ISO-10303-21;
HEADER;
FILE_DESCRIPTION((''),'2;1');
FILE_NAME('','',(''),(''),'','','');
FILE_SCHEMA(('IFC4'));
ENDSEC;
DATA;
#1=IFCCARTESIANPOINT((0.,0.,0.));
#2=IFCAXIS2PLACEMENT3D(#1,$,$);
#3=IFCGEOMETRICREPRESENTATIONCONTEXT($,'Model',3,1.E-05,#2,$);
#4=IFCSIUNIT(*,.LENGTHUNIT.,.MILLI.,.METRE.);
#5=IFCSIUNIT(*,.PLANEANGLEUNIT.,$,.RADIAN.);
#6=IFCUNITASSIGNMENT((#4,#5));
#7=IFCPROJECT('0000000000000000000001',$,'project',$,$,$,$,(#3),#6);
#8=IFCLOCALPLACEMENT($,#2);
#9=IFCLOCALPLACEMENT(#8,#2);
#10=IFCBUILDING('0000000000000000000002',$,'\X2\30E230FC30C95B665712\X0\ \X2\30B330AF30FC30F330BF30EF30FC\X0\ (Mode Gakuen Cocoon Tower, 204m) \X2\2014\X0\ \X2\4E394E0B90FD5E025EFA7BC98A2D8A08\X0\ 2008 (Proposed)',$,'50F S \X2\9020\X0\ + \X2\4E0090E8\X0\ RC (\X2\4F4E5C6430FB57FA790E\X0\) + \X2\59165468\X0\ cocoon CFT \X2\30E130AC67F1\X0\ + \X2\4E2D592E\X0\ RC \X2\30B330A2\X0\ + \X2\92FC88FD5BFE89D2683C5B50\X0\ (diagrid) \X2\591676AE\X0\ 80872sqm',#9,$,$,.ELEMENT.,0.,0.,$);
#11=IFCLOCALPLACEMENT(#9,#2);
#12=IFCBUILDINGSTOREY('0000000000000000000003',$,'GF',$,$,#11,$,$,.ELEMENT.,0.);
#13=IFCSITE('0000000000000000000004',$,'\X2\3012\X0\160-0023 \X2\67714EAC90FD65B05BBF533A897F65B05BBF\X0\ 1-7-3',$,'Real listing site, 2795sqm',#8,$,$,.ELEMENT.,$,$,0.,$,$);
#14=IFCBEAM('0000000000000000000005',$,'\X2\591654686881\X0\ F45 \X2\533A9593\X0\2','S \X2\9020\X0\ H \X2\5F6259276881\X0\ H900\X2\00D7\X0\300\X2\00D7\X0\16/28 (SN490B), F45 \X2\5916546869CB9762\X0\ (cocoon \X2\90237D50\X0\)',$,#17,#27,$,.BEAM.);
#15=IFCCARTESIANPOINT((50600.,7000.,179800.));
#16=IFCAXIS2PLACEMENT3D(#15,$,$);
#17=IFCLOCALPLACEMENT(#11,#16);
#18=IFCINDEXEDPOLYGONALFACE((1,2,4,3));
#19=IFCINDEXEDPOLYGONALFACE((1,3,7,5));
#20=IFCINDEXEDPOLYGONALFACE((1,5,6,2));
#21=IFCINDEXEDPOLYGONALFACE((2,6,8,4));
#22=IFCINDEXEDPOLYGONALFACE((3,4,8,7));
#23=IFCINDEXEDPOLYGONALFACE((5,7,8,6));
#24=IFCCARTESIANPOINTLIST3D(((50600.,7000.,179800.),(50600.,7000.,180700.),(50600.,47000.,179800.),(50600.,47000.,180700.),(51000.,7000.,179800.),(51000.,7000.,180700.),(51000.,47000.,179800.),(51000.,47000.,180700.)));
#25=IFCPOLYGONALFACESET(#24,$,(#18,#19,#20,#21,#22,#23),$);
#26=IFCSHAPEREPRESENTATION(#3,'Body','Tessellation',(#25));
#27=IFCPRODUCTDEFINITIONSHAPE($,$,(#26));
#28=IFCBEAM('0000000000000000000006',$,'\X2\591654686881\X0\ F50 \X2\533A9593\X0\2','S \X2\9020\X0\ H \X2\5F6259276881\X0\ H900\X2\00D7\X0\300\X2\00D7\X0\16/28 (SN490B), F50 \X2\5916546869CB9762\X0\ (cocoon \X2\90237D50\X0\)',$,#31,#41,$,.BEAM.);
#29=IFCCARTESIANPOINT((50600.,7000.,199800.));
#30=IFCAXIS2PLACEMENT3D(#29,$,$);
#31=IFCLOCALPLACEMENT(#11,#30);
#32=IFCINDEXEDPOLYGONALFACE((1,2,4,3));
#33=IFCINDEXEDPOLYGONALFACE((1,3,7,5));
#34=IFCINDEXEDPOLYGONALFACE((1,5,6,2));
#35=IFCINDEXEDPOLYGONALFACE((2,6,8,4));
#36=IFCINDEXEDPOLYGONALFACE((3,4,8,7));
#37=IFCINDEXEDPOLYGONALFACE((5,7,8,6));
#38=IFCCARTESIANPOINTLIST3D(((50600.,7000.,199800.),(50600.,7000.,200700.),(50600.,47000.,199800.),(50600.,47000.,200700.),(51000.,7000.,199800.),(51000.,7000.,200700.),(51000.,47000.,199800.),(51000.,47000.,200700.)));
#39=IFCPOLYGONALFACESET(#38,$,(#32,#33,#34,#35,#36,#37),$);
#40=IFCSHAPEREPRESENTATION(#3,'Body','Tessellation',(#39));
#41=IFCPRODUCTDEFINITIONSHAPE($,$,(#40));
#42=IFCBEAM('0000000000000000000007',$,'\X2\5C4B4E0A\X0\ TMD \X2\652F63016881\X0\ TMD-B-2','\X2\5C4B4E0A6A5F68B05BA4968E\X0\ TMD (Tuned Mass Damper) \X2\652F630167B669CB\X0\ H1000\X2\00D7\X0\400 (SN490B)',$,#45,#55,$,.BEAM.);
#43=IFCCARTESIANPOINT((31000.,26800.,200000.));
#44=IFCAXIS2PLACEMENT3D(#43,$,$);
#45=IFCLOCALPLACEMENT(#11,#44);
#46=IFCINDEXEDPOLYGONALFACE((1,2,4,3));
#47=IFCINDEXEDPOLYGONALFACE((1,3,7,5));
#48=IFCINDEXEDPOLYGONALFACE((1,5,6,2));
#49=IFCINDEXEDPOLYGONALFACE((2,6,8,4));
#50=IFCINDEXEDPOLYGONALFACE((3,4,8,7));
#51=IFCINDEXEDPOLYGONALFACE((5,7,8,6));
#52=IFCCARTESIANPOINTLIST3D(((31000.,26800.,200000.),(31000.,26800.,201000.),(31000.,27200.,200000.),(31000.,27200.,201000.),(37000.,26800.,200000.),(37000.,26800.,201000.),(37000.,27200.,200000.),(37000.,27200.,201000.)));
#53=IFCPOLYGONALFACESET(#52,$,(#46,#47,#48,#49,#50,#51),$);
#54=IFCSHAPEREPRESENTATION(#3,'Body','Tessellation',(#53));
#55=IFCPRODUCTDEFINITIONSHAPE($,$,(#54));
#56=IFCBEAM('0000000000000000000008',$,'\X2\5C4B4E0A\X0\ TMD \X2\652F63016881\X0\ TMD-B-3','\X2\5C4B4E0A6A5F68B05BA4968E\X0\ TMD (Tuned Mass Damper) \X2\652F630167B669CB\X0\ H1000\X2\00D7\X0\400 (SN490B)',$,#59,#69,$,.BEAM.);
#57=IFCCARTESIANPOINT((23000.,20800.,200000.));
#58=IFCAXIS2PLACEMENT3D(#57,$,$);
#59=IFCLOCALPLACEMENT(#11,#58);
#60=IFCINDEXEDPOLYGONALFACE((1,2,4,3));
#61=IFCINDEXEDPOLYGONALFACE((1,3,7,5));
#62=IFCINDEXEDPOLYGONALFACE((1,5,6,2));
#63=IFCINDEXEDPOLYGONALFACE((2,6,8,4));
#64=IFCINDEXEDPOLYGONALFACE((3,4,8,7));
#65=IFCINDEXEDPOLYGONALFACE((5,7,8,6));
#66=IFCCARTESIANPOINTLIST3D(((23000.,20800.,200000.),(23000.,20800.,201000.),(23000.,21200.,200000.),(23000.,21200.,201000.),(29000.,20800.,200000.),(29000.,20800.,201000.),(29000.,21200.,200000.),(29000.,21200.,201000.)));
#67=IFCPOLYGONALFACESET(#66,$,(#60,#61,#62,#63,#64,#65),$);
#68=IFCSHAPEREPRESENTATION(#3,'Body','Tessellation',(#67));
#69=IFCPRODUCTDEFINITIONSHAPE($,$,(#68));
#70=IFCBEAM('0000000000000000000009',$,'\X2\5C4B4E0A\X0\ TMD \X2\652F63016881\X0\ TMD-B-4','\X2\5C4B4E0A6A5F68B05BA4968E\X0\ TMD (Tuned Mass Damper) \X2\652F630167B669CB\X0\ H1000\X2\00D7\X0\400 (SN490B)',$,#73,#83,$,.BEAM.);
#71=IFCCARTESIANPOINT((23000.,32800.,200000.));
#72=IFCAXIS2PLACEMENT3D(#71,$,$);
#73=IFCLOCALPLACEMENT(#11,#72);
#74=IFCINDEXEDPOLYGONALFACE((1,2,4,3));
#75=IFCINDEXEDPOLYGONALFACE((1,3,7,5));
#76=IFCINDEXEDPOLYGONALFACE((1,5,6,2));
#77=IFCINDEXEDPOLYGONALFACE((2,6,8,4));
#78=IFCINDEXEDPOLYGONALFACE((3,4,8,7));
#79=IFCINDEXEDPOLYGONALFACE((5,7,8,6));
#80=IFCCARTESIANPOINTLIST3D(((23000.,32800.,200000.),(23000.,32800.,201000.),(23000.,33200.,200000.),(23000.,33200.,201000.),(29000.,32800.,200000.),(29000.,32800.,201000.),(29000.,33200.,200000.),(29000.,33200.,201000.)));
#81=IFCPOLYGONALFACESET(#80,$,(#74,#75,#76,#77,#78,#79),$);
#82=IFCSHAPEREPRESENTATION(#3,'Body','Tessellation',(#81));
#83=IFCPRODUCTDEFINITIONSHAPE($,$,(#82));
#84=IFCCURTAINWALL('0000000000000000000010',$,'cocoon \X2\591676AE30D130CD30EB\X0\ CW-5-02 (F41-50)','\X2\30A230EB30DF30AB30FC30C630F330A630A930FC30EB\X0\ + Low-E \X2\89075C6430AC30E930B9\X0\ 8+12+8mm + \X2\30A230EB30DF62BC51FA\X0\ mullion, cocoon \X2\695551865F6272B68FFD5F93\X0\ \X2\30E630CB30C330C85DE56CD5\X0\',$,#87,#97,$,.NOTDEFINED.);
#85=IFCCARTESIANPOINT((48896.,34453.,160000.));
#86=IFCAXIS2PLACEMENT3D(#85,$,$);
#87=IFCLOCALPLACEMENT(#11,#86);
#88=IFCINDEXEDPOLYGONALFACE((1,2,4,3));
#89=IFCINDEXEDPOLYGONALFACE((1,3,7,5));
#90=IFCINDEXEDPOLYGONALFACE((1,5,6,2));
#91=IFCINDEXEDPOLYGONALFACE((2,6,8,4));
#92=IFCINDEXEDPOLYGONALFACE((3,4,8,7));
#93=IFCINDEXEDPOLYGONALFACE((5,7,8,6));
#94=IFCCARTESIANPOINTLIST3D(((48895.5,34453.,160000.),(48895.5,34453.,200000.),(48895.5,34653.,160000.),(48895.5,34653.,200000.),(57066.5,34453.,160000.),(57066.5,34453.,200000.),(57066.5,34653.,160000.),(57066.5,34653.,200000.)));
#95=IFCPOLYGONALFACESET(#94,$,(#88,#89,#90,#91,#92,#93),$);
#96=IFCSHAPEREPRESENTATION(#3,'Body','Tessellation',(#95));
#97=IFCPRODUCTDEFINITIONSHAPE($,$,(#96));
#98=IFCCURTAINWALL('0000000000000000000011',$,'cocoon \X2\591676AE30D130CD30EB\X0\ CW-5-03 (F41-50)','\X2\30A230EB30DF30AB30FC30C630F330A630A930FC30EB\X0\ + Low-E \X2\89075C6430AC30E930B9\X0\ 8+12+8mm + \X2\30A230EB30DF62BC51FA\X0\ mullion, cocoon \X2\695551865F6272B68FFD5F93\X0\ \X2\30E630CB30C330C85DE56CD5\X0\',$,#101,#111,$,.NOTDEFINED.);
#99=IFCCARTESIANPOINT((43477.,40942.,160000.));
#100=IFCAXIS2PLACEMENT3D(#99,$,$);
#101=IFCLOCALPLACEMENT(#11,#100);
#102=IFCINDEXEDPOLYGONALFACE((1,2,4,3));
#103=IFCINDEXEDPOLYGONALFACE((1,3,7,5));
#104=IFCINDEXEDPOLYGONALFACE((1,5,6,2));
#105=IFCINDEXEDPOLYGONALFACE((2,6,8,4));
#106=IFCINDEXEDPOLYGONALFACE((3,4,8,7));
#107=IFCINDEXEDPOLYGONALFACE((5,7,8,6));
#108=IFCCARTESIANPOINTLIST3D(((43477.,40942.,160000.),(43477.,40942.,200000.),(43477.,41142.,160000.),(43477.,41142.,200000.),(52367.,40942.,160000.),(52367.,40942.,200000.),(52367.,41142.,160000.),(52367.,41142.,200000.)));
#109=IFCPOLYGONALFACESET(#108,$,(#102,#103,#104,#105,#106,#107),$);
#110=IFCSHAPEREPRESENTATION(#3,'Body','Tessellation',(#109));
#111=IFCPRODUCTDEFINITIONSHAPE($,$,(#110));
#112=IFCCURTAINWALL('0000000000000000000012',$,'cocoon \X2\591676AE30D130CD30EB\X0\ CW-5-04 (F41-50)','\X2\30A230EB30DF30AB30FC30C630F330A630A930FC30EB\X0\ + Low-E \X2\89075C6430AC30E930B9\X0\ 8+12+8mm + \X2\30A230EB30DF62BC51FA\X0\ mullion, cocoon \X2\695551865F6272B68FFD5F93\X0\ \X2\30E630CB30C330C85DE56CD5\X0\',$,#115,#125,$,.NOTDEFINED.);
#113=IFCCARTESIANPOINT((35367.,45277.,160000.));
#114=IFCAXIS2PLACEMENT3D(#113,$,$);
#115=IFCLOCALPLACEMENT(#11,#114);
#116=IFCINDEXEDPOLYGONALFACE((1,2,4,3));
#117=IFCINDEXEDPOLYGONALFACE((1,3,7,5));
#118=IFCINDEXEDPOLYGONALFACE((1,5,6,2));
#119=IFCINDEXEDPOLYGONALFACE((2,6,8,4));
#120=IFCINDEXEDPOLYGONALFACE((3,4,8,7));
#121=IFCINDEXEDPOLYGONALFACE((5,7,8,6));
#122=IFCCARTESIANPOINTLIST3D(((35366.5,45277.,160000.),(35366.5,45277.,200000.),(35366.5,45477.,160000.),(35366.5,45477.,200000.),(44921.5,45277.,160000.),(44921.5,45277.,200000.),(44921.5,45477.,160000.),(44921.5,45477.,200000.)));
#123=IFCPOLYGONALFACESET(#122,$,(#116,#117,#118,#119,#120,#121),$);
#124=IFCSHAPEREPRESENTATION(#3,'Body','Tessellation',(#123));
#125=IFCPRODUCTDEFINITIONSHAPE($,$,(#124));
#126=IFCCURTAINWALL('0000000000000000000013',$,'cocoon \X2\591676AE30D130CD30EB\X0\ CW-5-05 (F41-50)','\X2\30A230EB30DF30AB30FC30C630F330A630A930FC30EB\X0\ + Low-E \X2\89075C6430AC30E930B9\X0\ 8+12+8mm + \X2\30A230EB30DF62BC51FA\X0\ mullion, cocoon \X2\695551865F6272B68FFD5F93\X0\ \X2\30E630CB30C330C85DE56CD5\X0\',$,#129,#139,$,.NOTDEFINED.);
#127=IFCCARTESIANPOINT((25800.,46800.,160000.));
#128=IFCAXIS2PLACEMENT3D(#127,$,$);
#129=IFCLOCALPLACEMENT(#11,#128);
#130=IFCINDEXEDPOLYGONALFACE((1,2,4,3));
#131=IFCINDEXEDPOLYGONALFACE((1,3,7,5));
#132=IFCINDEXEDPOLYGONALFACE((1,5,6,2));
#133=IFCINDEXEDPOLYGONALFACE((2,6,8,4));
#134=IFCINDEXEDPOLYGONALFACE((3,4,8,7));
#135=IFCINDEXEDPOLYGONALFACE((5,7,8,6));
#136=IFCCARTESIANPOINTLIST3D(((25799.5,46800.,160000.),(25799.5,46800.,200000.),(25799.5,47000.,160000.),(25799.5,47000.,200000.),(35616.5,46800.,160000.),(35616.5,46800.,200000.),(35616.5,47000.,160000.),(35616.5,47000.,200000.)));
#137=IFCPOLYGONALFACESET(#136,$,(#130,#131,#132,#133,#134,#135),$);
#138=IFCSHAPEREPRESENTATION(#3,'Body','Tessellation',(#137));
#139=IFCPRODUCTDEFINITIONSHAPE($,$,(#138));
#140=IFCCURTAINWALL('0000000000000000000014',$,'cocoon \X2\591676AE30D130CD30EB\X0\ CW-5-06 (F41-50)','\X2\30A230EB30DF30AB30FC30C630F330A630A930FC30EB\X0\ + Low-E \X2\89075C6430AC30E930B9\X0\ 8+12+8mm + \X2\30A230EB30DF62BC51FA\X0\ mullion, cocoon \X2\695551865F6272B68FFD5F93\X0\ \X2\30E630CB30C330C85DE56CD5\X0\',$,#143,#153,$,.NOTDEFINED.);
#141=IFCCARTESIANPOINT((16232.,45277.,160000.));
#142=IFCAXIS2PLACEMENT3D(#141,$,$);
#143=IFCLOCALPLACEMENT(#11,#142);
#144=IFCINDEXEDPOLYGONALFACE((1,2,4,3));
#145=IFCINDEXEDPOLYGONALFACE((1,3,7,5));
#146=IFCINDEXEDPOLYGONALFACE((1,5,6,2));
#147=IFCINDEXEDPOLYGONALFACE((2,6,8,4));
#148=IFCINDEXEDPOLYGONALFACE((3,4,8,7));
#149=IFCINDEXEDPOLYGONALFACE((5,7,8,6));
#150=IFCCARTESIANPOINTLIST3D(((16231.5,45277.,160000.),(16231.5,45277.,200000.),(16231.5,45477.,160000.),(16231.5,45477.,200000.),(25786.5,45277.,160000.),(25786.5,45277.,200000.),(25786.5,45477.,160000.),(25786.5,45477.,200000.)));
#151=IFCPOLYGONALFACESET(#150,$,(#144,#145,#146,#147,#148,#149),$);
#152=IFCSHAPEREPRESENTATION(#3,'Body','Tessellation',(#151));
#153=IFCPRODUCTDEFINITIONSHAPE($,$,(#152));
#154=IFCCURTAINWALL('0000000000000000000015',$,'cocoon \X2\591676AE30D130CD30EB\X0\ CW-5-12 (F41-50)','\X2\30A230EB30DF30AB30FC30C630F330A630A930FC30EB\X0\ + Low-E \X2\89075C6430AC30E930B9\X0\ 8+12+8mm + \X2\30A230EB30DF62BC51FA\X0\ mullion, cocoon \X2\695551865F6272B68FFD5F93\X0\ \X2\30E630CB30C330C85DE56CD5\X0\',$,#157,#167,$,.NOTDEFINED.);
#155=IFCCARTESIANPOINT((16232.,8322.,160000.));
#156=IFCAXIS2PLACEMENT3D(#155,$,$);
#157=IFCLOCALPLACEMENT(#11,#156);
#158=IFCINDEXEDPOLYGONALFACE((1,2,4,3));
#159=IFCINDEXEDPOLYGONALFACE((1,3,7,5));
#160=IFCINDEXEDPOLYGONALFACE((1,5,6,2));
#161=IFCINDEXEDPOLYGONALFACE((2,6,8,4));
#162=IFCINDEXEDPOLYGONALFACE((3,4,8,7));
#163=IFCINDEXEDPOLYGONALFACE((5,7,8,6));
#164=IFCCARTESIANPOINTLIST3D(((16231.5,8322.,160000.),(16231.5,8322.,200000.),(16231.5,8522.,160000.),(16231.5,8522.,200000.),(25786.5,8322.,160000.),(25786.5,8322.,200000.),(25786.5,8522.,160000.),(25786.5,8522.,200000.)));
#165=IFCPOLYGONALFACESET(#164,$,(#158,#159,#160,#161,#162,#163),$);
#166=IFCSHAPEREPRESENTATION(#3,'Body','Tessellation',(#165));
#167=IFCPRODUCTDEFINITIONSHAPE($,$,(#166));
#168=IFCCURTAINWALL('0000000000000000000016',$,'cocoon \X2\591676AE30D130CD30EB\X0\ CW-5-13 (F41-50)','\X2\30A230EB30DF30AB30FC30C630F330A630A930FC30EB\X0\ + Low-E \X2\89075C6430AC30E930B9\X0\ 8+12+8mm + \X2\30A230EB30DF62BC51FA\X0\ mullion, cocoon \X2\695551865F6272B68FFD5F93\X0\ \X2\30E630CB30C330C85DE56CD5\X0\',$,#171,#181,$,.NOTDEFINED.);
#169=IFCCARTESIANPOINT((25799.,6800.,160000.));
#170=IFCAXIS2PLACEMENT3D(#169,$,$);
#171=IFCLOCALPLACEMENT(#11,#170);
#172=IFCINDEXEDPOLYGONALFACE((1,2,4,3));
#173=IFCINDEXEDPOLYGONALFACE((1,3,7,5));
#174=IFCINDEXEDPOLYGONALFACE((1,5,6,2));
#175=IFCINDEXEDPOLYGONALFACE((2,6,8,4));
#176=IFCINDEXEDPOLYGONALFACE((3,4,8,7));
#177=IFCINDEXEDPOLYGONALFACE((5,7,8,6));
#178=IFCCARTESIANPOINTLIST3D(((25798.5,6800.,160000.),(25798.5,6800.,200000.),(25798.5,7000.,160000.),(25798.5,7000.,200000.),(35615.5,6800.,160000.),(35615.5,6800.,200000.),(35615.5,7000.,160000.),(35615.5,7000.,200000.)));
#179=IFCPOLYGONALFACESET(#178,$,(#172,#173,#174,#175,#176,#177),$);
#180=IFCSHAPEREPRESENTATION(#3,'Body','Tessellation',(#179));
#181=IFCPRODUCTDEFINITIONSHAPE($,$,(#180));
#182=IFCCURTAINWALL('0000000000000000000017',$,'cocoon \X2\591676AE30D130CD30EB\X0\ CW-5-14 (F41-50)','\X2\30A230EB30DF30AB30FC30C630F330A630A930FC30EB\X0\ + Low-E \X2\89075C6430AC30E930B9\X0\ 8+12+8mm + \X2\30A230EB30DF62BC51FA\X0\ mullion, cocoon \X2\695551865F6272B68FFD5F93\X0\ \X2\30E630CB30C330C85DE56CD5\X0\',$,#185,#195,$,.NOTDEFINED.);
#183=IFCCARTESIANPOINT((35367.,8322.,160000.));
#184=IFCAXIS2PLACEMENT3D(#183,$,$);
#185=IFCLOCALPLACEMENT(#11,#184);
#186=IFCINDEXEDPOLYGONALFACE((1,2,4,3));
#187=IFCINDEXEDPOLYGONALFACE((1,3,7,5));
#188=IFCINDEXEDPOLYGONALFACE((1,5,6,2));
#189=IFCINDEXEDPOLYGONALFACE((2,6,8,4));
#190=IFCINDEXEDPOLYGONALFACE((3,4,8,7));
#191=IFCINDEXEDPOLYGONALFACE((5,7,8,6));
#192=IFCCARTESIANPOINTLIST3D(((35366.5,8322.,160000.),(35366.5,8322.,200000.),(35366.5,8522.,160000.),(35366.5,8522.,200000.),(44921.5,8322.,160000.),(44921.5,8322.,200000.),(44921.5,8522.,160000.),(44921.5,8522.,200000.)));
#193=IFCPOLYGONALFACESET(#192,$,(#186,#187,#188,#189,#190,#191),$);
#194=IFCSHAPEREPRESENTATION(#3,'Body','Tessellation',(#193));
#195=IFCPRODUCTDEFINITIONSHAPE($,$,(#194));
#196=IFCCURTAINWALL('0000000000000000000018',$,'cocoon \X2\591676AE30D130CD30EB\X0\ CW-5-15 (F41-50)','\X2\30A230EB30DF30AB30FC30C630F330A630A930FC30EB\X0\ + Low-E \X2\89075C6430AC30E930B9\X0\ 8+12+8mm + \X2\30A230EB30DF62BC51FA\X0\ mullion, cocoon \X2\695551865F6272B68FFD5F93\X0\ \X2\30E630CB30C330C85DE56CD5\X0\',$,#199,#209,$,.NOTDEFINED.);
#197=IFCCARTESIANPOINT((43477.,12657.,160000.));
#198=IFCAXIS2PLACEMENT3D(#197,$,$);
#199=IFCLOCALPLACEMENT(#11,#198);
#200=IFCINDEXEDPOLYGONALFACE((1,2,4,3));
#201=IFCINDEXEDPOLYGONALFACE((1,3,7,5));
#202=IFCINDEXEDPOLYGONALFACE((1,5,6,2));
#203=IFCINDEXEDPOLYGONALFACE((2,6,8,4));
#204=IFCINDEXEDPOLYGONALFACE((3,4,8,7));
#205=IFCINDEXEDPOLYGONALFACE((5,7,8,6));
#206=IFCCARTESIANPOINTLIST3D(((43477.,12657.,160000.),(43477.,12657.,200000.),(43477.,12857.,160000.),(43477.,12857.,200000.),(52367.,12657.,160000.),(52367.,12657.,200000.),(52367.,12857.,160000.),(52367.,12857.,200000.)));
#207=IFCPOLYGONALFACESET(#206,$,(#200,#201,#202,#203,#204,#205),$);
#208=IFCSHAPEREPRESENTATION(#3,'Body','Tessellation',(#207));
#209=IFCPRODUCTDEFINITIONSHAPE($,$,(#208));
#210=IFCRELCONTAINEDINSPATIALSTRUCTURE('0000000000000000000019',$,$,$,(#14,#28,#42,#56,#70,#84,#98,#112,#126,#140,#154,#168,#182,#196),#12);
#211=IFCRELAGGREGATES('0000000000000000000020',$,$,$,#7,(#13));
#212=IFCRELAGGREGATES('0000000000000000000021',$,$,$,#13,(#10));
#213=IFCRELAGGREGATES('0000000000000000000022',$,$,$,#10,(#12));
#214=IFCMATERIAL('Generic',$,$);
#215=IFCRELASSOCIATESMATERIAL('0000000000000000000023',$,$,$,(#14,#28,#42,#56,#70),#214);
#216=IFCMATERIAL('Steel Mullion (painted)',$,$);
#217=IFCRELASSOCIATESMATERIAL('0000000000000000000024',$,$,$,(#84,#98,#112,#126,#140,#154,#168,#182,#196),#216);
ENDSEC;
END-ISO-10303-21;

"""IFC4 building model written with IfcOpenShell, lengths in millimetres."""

from ifc_helpers import new_model, si_unit, frame, frame_2d, origin, place, context, project, spatial, rectangle, extrude, material, element, save


model = new_model("IFC4")

# Units and contexts
model_context = context("Model", 3, precision=1e-05, world=origin())
ifc_project = project(units=[si_unit("LENGTHUNIT", "METRE", prefix="MILLI"), si_unit("PLANEANGLEUNIT", "RADIAN")], contexts=[model_context])

# Site, building, storey
site_placement = place(None, origin())
site = spatial("IfcSite", under=ifc_project, at=site_placement, Name="〒160-0023 東京都新宿区西新宿 1-7-3", ObjectType="Real listing site, 2795sqm", CompositionType="ELEMENT", RefElevation=0.0)
building_placement = place(site_placement, origin())
building = spatial("IfcBuilding", under=site, at=building_placement, Name="モード学園 コクーンタワー (Mode Gakuen Cocoon Tower, 204m) — 丹下都市建築設計 2008 (Proposed)", ObjectType="50F S 造 + 一部 RC (低層・基礎) + 外周 cocoon CFT メガ柱 + 中央 RC コア + 鋼製対角格子 (diagrid) 外皮 80872sqm", CompositionType="ELEMENT", ElevationOfRefHeight=0.0, ElevationOfTerrain=0.0)
storey_placement = place(building_placement, origin())
storey = spatial("IfcBuildingStorey", under=building, at=storey_placement, Name="GF", CompositionType="ELEMENT", Elevation=0.0)

# Beams
ifc_material_1 = material(Name="Generic")
beam_1_placement = place(storey_placement, frame((50600.0, 7000.0, 179800.0)))
element("IfcBeam", 1, at=beam_1_placement, inside=storey, material=ifc_material_1, Name="外周梁 F45 区間2", Description="S 造 H 形大梁 H900×300×16/28 (SN490B), F45 外周構面 (cocoon 連結)", PredefinedType="BEAM", context=model_context, shape_type="SweptSolid", body=[
    extrude(rectangle(XDim=400.0, YDim=40000.0, at=frame_2d((200.0, 20000.0))), frame((50600.0, 7000.0, 179800.0)), (0.0, 0.0, 1.0), 900.0),
])
beam_2_placement = place(storey_placement, frame((50600.0, 7000.0, 199800.0)))
element("IfcBeam", 2, at=beam_2_placement, inside=storey, material=ifc_material_1, Name="外周梁 F50 区間2", Description="S 造 H 形大梁 H900×300×16/28 (SN490B), F50 外周構面 (cocoon 連結)", PredefinedType="BEAM", context=model_context, shape_type="SweptSolid", body=[
    extrude(rectangle(XDim=400.0, YDim=40000.0, at=frame_2d((200.0, 20000.0))), frame((50600.0, 7000.0, 199800.0)), (0.0, 0.0, 1.0), 900.0),
])
beam_3_placement = place(storey_placement, frame((31000.0, 26800.0, 200000.0)))
element("IfcBeam", 3, at=beam_3_placement, inside=storey, material=ifc_material_1, Name="屋上 TMD 支持梁 TMD-B-2", Description="屋上機械室階 TMD (Tuned Mass Damper) 支持架構 H1000×400 (SN490B)", PredefinedType="BEAM", context=model_context, shape_type="SweptSolid", body=[
    extrude(rectangle(XDim=6000.0, YDim=400.0, at=frame_2d((3000.0, 200.0))), frame((31000.0, 26800.0, 200000.0)), (0.0, 0.0, 1.0), 1000.0),
])
beam_4_placement = place(storey_placement, frame((23000.0, 20800.0, 200000.0)))
element("IfcBeam", 4, at=beam_4_placement, inside=storey, material=ifc_material_1, Name="屋上 TMD 支持梁 TMD-B-3", Description="屋上機械室階 TMD (Tuned Mass Damper) 支持架構 H1000×400 (SN490B)", PredefinedType="BEAM", context=model_context, shape_type="SweptSolid", body=[
    extrude(rectangle(XDim=6000.0, YDim=400.0, at=frame_2d((3000.0, 200.0))), frame((23000.0, 20800.0, 200000.0)), (0.0, 0.0, 1.0), 1000.0),
])
beam_5_placement = place(storey_placement, frame((23000.0, 32800.0, 200000.0)))
element("IfcBeam", 5, at=beam_5_placement, inside=storey, material=ifc_material_1, Name="屋上 TMD 支持梁 TMD-B-4", Description="屋上機械室階 TMD (Tuned Mass Damper) 支持架構 H1000×400 (SN490B)", PredefinedType="BEAM", context=model_context, shape_type="SweptSolid", body=[
    extrude(rectangle(XDim=6000.0, YDim=400.0, at=frame_2d((3000.0, 200.0))), frame((23000.0, 32800.0, 200000.0)), (0.0, 0.0, 1.0), 1000.0),
])

# Curtain walls
ifc_material_2 = material(Name="Steel Mullion (painted)")
curtain_wall_1_placement = place(storey_placement, frame((48896.0, 34453.0, 160000.0)))
element("IfcCurtainWall", 6, at=curtain_wall_1_placement, inside=storey, material=ifc_material_2, Name="cocoon 外皮パネル CW-5-02 (F41-50)", Description="アルミカーテンウォール + Low-E 複層ガラス 8+12+8mm + アルミ押出 mullion, cocoon 楕円形状追従 ユニット工法", PredefinedType="NOTDEFINED", context=model_context, shape_type="SweptSolid", body=[
    extrude(rectangle(XDim=8171.0, YDim=200.0, at=frame_2d((4085.0, 100.0))), frame((48896.0, 34453.0, 160000.0)), (0.0, 0.0, 1.0), 40000.0),
])
curtain_wall_2_placement = place(storey_placement, frame((43477.0, 40942.0, 160000.0)))
element("IfcCurtainWall", 7, at=curtain_wall_2_placement, inside=storey, material=ifc_material_2, Name="cocoon 外皮パネル CW-5-03 (F41-50)", Description="アルミカーテンウォール + Low-E 複層ガラス 8+12+8mm + アルミ押出 mullion, cocoon 楕円形状追従 ユニット工法", PredefinedType="NOTDEFINED", context=model_context, shape_type="SweptSolid", body=[
    extrude(rectangle(XDim=8890.0, YDim=200.0, at=frame_2d((4445.0, 100.0))), frame((43477.0, 40942.0, 160000.0)), (0.0, 0.0, 1.0), 40000.0),
])
curtain_wall_3_placement = place(storey_placement, frame((35367.0, 45277.0, 160000.0)))
element("IfcCurtainWall", 8, at=curtain_wall_3_placement, inside=storey, material=ifc_material_2, Name="cocoon 外皮パネル CW-5-04 (F41-50)", Description="アルミカーテンウォール + Low-E 複層ガラス 8+12+8mm + アルミ押出 mullion, cocoon 楕円形状追従 ユニット工法", PredefinedType="NOTDEFINED", context=model_context, shape_type="SweptSolid", body=[
    extrude(rectangle(XDim=9555.0, YDim=200.0, at=frame_2d((4777.0, 100.0))), frame((35367.0, 45277.0, 160000.0)), (0.0, 0.0, 1.0), 40000.0),
])
curtain_wall_4_placement = place(storey_placement, frame((25800.0, 46800.0, 160000.0)))
element("IfcCurtainWall", 9, at=curtain_wall_4_placement, inside=storey, material=ifc_material_2, Name="cocoon 外皮パネル CW-5-05 (F41-50)", Description="アルミカーテンウォール + Low-E 複層ガラス 8+12+8mm + アルミ押出 mullion, cocoon 楕円形状追従 ユニット工法", PredefinedType="NOTDEFINED", context=model_context, shape_type="SweptSolid", body=[
    extrude(rectangle(XDim=9817.0, YDim=200.0, at=frame_2d((4908.0, 100.0))), frame((25800.0, 46800.0, 160000.0)), (0.0, 0.0, 1.0), 40000.0),
])
curtain_wall_5_placement = place(storey_placement, frame((16232.0, 45277.0, 160000.0)))
element("IfcCurtainWall", 10, at=curtain_wall_5_placement, inside=storey, material=ifc_material_2, Name="cocoon 外皮パネル CW-5-06 (F41-50)", Description="アルミカーテンウォール + Low-E 複層ガラス 8+12+8mm + アルミ押出 mullion, cocoon 楕円形状追従 ユニット工法", PredefinedType="NOTDEFINED", context=model_context, shape_type="SweptSolid", body=[
    extrude(rectangle(XDim=9555.0, YDim=200.0, at=frame_2d((4777.0, 100.0))), frame((16232.0, 45277.0, 160000.0)), (0.0, 0.0, 1.0), 40000.0),
])
curtain_wall_6_placement = place(storey_placement, frame((16232.0, 8322.0, 160000.0)))
element("IfcCurtainWall", 11, at=curtain_wall_6_placement, inside=storey, material=ifc_material_2, Name="cocoon 外皮パネル CW-5-12 (F41-50)", Description="アルミカーテンウォール + Low-E 複層ガラス 8+12+8mm + アルミ押出 mullion, cocoon 楕円形状追従 ユニット工法", PredefinedType="NOTDEFINED", context=model_context, shape_type="SweptSolid", body=[
    extrude(rectangle(XDim=9555.0, YDim=200.0, at=frame_2d((4777.0, 100.0))), frame((16232.0, 8322.0, 160000.0)), (0.0, 0.0, 1.0), 40000.0),
])
curtain_wall_7_placement = place(storey_placement, frame((25799.0, 6800.0, 160000.0)))
element("IfcCurtainWall", 12, at=curtain_wall_7_placement, inside=storey, material=ifc_material_2, Name="cocoon 外皮パネル CW-5-13 (F41-50)", Description="アルミカーテンウォール + Low-E 複層ガラス 8+12+8mm + アルミ押出 mullion, cocoon 楕円形状追従 ユニット工法", PredefinedType="NOTDEFINED", context=model_context, shape_type="SweptSolid", body=[
    extrude(rectangle(XDim=9817.0, YDim=200.0, at=frame_2d((4908.0, 100.0))), frame((25799.0, 6800.0, 160000.0)), (0.0, 0.0, 1.0), 40000.0),
])
curtain_wall_8_placement = place(storey_placement, frame((35367.0, 8322.0, 160000.0)))
element("IfcCurtainWall", 13, at=curtain_wall_8_placement, inside=storey, material=ifc_material_2, Name="cocoon 外皮パネル CW-5-14 (F41-50)", Description="アルミカーテンウォール + Low-E 複層ガラス 8+12+8mm + アルミ押出 mullion, cocoon 楕円形状追従 ユニット工法", PredefinedType="NOTDEFINED", context=model_context, shape_type="SweptSolid", body=[
    extrude(rectangle(XDim=9555.0, YDim=200.0, at=frame_2d((4777.0, 100.0))), frame((35367.0, 8322.0, 160000.0)), (0.0, 0.0, 1.0), 40000.0),
])
curtain_wall_9_placement = place(storey_placement, frame((43477.0, 12657.0, 160000.0)))
element("IfcCurtainWall", 14, at=curtain_wall_9_placement, inside=storey, material=ifc_material_2, Name="cocoon 外皮パネル CW-5-15 (F41-50)", Description="アルミカーテンウォール + Low-E 複層ガラス 8+12+8mm + アルミ押出 mullion, cocoon 楕円形状追従 ユニット工法", PredefinedType="NOTDEFINED", context=model_context, shape_type="SweptSolid", body=[
    extrude(rectangle(XDim=8890.0, YDim=200.0, at=frame_2d((4445.0, 100.0))), frame((43477.0, 12657.0, 160000.0)), (0.0, 0.0, 1.0), 40000.0),
])

save(model, "model.ifc")
